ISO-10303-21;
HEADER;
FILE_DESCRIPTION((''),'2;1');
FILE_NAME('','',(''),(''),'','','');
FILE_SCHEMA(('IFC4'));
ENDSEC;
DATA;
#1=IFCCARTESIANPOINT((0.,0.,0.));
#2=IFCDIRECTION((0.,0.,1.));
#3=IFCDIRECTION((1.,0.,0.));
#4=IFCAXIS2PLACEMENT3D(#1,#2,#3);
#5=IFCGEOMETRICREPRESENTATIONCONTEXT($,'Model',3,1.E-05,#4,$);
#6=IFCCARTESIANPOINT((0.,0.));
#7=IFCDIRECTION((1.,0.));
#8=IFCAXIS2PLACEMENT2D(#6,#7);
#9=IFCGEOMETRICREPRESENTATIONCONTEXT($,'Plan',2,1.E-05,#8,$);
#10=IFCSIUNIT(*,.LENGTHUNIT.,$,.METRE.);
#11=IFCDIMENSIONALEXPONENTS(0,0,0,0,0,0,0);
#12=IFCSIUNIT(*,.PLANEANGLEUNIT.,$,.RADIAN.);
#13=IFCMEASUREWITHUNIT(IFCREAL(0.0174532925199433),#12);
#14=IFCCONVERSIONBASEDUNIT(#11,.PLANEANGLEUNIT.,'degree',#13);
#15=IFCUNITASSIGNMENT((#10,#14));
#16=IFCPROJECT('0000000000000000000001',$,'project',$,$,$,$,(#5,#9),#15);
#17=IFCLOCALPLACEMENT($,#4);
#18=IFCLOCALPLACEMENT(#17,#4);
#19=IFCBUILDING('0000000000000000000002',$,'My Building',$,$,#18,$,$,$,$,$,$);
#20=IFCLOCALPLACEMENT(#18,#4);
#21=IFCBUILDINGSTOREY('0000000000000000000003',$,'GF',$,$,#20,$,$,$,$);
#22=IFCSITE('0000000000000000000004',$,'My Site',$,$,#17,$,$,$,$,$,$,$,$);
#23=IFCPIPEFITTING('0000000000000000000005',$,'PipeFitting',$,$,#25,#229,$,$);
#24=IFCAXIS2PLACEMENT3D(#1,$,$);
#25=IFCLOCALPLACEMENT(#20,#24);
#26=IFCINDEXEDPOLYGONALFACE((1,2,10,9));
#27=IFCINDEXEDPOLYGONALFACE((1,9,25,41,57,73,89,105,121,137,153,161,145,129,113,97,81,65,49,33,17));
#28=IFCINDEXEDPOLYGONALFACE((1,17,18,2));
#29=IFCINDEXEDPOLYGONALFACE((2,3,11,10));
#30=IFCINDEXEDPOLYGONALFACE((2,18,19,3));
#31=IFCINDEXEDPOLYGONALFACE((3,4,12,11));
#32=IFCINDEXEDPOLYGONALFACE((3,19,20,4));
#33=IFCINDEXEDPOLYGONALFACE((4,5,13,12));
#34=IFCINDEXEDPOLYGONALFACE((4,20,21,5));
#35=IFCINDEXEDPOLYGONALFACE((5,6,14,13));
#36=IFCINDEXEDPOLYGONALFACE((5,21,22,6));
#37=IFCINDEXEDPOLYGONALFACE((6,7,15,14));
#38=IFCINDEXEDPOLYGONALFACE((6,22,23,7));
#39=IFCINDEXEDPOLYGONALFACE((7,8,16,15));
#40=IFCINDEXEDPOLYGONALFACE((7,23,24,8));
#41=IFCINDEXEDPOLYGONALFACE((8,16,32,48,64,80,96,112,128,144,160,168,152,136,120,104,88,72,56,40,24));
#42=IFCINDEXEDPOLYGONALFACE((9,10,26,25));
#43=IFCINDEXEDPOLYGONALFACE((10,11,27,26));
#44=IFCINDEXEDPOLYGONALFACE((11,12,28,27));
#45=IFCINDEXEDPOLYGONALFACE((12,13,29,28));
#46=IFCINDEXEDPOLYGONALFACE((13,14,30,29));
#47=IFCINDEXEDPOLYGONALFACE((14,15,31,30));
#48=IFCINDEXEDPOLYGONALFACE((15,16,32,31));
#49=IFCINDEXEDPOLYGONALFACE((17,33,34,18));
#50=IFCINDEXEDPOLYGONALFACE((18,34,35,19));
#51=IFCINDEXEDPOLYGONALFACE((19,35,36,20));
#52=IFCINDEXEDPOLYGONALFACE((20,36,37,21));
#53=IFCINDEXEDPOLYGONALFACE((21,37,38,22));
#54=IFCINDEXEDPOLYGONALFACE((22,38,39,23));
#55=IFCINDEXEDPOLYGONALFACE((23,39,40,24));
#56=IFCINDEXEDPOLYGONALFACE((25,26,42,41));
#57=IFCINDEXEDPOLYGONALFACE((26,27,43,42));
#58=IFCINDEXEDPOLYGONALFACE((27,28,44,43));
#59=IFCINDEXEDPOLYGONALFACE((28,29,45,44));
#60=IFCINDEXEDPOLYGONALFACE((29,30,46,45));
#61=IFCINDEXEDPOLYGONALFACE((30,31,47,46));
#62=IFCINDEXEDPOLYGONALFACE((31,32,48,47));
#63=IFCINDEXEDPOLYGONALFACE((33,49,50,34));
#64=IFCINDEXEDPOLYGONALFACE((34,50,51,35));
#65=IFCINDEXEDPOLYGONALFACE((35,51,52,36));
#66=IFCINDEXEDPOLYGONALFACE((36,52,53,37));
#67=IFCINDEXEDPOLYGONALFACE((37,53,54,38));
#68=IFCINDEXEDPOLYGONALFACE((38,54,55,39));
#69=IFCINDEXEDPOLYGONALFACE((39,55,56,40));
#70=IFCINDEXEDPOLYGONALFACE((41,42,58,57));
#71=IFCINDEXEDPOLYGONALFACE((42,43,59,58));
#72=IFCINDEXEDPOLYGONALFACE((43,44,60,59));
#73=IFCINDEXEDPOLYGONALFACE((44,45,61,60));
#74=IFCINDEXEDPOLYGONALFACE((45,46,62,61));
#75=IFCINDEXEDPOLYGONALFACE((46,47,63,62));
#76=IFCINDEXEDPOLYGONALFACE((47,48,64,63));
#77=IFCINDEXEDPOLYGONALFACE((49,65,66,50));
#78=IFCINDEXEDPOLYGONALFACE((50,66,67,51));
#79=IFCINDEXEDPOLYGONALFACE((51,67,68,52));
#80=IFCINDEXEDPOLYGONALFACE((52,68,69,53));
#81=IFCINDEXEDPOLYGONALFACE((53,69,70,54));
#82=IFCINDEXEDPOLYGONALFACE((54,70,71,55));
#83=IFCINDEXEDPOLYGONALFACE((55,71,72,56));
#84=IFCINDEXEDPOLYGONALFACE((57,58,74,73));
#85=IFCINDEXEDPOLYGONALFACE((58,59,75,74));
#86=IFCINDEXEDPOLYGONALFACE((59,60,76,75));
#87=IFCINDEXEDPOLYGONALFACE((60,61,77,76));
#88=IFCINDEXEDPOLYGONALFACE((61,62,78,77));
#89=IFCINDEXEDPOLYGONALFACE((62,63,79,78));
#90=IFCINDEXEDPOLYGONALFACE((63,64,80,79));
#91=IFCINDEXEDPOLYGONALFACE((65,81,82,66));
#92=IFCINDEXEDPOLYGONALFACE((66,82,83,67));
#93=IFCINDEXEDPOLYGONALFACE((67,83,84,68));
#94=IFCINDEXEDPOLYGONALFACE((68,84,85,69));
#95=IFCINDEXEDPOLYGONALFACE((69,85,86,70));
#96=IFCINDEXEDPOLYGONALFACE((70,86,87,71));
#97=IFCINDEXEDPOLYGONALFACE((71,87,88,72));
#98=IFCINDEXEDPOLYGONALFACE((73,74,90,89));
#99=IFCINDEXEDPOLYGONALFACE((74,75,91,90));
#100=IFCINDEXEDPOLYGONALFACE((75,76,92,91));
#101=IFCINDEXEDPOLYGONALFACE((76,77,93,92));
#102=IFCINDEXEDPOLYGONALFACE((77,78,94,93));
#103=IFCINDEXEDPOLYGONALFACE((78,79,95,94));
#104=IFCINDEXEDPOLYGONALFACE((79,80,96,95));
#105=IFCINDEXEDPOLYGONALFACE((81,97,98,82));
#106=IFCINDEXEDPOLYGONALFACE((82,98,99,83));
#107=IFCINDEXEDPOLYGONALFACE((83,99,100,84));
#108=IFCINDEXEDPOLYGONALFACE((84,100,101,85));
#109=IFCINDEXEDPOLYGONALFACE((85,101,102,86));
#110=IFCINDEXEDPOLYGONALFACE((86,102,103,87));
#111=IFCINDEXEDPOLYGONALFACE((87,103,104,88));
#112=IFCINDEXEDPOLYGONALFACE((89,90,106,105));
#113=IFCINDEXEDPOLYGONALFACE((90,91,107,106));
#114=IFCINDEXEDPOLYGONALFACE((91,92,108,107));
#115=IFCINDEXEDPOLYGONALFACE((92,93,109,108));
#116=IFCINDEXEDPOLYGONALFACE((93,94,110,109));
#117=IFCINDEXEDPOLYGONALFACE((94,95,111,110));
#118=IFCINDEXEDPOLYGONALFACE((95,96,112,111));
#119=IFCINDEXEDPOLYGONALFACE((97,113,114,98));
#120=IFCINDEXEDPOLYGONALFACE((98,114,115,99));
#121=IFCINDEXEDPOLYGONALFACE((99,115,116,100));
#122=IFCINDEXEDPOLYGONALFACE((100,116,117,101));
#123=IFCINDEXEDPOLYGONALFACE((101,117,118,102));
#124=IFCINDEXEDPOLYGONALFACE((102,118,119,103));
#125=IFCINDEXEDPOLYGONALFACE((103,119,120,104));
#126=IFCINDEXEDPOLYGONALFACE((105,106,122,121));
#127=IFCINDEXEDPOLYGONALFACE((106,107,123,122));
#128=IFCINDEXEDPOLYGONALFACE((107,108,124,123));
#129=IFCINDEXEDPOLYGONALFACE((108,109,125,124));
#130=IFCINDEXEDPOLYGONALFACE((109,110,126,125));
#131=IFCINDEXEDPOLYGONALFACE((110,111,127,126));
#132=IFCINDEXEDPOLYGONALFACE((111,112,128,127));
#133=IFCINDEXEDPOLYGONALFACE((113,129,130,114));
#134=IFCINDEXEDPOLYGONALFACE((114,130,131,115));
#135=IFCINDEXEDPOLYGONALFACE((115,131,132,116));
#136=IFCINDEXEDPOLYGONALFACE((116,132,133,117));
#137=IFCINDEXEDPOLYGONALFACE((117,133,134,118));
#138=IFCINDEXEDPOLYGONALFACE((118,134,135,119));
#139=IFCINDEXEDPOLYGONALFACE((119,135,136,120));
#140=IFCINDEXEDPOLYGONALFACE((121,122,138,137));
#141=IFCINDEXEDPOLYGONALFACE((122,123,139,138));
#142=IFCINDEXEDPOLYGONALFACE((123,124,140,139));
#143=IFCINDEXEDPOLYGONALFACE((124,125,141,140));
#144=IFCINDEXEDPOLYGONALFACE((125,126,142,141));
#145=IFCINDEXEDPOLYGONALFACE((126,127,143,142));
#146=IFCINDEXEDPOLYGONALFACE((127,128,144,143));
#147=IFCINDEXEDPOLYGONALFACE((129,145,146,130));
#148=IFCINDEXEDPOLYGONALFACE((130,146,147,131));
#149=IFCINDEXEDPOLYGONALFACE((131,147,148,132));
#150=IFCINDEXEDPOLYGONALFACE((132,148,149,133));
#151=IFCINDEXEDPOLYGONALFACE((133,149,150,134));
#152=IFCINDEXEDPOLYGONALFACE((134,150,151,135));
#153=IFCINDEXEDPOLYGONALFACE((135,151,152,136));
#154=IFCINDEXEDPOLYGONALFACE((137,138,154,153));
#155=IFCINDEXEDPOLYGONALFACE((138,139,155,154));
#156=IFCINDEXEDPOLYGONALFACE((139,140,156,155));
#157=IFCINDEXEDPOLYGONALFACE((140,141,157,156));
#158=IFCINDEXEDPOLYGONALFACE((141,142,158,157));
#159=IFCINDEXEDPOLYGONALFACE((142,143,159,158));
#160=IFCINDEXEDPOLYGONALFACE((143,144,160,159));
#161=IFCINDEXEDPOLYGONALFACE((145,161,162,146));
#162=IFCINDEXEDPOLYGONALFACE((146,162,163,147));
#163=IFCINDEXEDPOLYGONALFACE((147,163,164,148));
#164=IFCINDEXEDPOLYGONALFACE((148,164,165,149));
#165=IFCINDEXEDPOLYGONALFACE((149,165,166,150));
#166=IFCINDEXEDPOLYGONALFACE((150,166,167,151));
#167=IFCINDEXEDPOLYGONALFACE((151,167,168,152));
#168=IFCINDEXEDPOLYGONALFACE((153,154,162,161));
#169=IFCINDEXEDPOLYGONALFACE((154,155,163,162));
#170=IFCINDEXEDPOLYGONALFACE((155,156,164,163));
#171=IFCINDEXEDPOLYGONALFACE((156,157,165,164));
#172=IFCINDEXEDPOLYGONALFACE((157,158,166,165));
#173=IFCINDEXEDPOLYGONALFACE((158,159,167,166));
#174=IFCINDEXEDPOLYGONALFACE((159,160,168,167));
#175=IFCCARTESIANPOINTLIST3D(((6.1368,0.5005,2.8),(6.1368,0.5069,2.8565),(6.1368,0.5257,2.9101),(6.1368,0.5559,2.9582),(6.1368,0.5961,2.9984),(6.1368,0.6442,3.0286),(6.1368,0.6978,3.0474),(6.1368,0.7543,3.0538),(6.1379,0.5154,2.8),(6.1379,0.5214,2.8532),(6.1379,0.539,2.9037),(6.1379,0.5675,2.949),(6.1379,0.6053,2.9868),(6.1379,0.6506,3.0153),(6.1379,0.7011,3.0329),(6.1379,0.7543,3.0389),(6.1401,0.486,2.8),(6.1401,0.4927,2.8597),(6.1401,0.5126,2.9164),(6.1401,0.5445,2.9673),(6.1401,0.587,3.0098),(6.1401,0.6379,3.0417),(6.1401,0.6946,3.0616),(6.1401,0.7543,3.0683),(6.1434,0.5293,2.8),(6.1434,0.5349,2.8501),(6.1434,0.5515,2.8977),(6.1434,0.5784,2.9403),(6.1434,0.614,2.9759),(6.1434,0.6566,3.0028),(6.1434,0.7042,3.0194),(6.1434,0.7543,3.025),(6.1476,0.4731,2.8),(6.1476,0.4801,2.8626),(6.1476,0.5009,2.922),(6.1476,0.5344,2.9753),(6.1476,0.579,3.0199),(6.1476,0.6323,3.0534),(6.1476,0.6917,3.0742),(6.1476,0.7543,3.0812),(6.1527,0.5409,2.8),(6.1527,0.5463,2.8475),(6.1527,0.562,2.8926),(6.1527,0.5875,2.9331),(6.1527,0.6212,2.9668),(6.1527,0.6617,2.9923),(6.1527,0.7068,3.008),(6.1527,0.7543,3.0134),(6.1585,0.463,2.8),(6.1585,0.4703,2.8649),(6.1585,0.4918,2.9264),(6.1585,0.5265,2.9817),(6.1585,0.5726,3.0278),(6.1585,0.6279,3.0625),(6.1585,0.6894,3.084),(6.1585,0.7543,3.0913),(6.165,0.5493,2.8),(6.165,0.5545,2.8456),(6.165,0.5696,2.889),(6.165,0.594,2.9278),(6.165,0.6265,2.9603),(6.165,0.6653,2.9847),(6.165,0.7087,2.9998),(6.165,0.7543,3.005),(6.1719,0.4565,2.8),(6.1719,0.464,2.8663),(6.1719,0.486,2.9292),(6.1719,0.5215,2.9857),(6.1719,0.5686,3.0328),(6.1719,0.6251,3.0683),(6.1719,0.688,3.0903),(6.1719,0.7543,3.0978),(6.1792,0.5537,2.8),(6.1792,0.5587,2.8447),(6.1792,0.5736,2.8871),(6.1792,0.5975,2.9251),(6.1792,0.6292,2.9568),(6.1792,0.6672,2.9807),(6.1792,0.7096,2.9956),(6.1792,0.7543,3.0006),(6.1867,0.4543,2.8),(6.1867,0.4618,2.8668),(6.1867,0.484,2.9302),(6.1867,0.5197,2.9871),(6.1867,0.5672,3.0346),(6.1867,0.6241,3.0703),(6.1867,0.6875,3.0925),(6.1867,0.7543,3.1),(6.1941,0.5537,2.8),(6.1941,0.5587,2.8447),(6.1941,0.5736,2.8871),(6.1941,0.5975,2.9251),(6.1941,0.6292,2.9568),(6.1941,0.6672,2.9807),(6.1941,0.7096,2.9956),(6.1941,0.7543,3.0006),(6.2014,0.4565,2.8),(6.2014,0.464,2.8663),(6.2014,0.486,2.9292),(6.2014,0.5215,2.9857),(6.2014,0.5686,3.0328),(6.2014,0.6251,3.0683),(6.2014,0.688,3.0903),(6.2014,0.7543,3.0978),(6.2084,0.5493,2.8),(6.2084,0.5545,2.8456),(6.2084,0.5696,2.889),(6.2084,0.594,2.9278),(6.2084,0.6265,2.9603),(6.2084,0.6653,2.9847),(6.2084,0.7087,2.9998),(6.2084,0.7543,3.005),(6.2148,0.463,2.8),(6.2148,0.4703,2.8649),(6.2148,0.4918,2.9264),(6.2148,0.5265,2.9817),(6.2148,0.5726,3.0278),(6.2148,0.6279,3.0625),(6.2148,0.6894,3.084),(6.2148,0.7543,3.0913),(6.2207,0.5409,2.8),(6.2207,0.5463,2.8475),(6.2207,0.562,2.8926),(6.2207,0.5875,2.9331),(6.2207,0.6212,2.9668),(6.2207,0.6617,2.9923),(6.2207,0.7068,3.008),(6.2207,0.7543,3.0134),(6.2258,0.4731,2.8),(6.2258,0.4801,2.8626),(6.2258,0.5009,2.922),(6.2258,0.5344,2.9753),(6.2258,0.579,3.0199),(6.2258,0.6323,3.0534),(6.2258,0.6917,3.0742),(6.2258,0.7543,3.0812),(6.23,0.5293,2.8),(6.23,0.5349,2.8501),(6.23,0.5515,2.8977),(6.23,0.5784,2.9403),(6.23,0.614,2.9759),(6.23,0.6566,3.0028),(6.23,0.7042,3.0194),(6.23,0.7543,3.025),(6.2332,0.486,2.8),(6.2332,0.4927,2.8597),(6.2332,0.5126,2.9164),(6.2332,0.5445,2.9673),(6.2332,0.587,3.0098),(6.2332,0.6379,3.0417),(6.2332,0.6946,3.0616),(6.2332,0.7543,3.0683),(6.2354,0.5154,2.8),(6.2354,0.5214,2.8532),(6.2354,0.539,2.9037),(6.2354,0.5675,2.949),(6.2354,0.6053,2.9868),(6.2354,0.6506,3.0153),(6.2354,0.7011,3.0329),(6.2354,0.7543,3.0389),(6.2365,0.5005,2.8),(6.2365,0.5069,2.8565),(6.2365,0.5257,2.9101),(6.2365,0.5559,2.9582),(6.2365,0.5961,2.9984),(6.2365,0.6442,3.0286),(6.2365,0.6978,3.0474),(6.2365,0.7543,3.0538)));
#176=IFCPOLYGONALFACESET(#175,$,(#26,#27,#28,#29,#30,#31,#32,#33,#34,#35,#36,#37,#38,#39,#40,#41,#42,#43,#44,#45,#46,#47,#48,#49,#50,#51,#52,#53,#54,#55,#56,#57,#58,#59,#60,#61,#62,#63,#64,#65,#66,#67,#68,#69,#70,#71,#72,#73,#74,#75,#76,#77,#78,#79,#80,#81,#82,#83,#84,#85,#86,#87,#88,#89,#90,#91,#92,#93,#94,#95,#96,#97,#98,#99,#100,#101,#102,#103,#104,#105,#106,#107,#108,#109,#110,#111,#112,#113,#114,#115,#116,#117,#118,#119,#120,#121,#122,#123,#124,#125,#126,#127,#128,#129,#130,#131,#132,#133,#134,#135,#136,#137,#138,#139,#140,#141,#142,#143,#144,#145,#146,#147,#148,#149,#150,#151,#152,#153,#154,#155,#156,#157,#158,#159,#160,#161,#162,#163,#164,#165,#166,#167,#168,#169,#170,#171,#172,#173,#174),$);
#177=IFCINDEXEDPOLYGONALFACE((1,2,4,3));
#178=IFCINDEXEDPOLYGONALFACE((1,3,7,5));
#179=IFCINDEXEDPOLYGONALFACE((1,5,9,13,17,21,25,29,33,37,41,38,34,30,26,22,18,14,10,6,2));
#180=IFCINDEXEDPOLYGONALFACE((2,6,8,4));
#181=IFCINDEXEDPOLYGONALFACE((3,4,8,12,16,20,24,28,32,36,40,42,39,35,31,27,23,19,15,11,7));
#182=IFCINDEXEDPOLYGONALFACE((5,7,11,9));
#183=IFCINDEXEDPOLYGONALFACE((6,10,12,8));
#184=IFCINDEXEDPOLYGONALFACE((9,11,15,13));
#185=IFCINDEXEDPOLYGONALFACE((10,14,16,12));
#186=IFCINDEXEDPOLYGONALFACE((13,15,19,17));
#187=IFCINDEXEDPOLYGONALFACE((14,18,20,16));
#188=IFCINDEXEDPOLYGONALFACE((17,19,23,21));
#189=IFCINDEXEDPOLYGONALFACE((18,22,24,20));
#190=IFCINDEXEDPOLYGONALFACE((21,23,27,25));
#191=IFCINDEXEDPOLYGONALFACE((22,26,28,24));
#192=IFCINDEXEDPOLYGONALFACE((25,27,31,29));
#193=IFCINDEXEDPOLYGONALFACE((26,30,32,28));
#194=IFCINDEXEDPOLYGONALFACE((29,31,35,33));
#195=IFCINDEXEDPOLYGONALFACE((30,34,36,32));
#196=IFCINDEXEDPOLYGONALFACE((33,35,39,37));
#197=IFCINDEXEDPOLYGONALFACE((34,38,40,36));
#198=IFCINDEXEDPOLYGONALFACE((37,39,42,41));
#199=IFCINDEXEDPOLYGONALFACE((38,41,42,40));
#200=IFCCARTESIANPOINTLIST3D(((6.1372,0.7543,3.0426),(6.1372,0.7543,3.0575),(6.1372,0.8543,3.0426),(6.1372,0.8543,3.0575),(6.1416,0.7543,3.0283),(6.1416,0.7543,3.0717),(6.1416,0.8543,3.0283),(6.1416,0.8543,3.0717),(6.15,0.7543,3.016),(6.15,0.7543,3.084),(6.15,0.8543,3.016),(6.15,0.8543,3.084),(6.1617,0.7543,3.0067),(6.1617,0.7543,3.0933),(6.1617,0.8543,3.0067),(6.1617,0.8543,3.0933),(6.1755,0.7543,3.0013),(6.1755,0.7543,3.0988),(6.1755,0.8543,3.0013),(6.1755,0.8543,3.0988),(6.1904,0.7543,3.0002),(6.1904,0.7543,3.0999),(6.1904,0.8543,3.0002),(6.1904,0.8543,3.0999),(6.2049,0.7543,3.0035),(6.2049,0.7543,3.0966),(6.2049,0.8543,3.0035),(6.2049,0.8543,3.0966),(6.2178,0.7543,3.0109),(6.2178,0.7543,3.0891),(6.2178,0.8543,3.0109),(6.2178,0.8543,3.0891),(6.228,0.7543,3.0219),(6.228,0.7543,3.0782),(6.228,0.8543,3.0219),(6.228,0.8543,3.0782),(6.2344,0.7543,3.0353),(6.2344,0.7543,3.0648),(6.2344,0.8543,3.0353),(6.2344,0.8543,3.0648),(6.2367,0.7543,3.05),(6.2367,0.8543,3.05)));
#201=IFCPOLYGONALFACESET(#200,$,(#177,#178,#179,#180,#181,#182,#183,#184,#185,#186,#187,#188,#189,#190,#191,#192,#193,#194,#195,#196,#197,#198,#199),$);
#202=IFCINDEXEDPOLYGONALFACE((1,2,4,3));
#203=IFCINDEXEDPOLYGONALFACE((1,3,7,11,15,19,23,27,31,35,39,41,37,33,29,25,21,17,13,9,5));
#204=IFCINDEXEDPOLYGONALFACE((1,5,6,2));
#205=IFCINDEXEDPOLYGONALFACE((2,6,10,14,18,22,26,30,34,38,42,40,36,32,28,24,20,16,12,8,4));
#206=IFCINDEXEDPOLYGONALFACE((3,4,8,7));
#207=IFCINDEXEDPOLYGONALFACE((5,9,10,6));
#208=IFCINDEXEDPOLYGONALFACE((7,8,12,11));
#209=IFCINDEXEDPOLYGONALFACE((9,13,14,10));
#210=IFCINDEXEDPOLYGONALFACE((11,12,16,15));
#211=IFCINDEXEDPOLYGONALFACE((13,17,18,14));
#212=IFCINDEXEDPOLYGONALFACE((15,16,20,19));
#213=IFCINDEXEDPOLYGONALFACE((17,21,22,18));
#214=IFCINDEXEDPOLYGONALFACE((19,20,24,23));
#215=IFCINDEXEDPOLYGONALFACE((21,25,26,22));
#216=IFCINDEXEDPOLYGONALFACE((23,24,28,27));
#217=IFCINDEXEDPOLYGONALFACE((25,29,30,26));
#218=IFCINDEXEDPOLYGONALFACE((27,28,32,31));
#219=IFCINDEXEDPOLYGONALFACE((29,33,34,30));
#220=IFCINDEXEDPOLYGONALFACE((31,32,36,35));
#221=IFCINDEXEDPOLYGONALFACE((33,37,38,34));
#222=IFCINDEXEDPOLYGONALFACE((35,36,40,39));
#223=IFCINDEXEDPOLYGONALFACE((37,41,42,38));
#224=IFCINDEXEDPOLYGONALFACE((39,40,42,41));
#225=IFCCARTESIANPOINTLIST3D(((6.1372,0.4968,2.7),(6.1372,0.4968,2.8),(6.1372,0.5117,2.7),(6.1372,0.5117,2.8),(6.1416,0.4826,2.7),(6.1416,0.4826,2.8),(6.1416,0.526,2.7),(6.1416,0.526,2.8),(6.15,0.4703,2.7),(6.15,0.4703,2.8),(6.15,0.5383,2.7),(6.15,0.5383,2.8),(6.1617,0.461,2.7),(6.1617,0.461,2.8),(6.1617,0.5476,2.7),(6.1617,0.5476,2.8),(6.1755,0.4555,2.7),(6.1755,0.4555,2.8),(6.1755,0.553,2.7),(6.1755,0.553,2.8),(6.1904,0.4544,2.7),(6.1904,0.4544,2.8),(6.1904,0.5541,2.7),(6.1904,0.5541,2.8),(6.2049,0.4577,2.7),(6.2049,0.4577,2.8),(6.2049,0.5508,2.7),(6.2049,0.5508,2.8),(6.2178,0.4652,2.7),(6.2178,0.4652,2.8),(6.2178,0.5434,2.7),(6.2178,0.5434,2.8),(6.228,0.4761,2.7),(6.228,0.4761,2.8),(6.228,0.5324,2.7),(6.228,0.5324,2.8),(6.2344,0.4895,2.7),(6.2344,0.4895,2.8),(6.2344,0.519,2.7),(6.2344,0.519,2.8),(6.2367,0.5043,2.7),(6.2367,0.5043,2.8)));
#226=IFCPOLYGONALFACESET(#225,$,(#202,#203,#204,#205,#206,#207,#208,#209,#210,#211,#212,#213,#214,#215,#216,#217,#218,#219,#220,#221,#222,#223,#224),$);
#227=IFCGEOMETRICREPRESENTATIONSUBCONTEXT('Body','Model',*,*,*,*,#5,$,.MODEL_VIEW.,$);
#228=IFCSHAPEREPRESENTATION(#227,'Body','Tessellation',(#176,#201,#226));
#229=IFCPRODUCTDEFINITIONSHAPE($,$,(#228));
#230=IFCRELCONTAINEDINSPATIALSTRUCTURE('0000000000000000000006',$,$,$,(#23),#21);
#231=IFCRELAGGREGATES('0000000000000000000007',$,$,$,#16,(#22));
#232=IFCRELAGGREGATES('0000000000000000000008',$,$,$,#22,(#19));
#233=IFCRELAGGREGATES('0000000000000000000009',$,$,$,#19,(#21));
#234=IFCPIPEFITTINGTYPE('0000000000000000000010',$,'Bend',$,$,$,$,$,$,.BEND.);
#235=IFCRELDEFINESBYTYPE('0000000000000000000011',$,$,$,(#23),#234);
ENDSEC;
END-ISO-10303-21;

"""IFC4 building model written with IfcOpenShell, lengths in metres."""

from ifc_helpers import new_model, entity, si_unit, converted_unit, frame, origin_with_axes, origin_2d_with_axis, place, context, subcontext, project, spatial, circle, extrude, source, transform, mapped, type_object, type_shapes, element, save


model = new_model("IFC4")

# Units and contexts
model_context = context("Model", 3, precision=1e-05, world=origin_with_axes())
plan_context = context("Plan", 2, precision=1e-05, world=origin_2d_with_axis())
body_context_1 = subcontext(model_context, "Body", "Model", "MODEL_VIEW")
ifc_project = project(units=[si_unit("LENGTHUNIT", "METRE"), converted_unit("PLANEANGLEUNIT", "degree", entity("IfcReal", 0.0174532925199433), si_unit("PLANEANGLEUNIT", "RADIAN"), dimensions=[0, 0, 0, 0, 0, 0, 0])], contexts=[model_context, plan_context])

# Site, building, storey
site_placement = place(None, origin_with_axes())
site = spatial("IfcSite", under=ifc_project, at=site_placement, Name="My Site")
building_placement = place(site_placement, origin_with_axes())
building = spatial("IfcBuilding", under=site, at=building_placement, Name="My Building")
storey_placement = place(building_placement, origin_with_axes())
storey = spatial("IfcBuildingStorey", under=building, at=storey_placement, Name="GF")

# Pipe fitting
pipe_fitting_type = type_object("IfcPipeFittingType", Name="Bend", PredefinedType="BEND")
shared_shape_1 = source(origin_with_axes(), body_context_1, "Body", "SolidModel", [
    entity("IfcSweptDiskSolid", entity("IfcIndexedPolyCurve", entity("IfcCartesianPointList3D", [[0.0, 0.0, 0.1], [0.0, -0.0732, 0.2768], [0.0, -0.25, 0.35]]), [entity("IfcArcIndex", [1, 2, 3])]), 0.05),
    extrude(circle(Radius=0.05), origin_with_axes(), (0.0, 0.0, 1.0), 0.1),
    extrude(circle(Radius=0.05), frame((0.0, -0.25, 0.35), z_axis=(0.0, -1.0, 0.0), x_axis=(1.0, 0.0, 0.0)), (0.0, 0.0, 1.0), 0.1),
])
type_shapes(pipe_fitting_type, [shared_shape_1])
for number, where, z_axis, x_axis, name in (
    (1, (6.1867, 0.8543, 3.05), (0.0, -1.0, 0.0), (1.0, 0.0, 0.0), "PipeFitting"),
):
    element("IfcPipeFitting", number, at=place(storey_placement, frame(where, z_axis=z_axis, x_axis=x_axis)), inside=storey, type_object=pipe_fitting_type, Name=name, context=body_context_1, shape_type="MappedRepresentation", body=[
        mapped(shared_shape_1, transform((0.0, 0.0, 0.0), x_axis=(1.0, 0.0, 0.0), y_axis=(0.0, 1.0, 0.0), z_axis=(0.0, 0.0, 1.0), scale=1.0)),
    ])

save(model, "model.ifc")
